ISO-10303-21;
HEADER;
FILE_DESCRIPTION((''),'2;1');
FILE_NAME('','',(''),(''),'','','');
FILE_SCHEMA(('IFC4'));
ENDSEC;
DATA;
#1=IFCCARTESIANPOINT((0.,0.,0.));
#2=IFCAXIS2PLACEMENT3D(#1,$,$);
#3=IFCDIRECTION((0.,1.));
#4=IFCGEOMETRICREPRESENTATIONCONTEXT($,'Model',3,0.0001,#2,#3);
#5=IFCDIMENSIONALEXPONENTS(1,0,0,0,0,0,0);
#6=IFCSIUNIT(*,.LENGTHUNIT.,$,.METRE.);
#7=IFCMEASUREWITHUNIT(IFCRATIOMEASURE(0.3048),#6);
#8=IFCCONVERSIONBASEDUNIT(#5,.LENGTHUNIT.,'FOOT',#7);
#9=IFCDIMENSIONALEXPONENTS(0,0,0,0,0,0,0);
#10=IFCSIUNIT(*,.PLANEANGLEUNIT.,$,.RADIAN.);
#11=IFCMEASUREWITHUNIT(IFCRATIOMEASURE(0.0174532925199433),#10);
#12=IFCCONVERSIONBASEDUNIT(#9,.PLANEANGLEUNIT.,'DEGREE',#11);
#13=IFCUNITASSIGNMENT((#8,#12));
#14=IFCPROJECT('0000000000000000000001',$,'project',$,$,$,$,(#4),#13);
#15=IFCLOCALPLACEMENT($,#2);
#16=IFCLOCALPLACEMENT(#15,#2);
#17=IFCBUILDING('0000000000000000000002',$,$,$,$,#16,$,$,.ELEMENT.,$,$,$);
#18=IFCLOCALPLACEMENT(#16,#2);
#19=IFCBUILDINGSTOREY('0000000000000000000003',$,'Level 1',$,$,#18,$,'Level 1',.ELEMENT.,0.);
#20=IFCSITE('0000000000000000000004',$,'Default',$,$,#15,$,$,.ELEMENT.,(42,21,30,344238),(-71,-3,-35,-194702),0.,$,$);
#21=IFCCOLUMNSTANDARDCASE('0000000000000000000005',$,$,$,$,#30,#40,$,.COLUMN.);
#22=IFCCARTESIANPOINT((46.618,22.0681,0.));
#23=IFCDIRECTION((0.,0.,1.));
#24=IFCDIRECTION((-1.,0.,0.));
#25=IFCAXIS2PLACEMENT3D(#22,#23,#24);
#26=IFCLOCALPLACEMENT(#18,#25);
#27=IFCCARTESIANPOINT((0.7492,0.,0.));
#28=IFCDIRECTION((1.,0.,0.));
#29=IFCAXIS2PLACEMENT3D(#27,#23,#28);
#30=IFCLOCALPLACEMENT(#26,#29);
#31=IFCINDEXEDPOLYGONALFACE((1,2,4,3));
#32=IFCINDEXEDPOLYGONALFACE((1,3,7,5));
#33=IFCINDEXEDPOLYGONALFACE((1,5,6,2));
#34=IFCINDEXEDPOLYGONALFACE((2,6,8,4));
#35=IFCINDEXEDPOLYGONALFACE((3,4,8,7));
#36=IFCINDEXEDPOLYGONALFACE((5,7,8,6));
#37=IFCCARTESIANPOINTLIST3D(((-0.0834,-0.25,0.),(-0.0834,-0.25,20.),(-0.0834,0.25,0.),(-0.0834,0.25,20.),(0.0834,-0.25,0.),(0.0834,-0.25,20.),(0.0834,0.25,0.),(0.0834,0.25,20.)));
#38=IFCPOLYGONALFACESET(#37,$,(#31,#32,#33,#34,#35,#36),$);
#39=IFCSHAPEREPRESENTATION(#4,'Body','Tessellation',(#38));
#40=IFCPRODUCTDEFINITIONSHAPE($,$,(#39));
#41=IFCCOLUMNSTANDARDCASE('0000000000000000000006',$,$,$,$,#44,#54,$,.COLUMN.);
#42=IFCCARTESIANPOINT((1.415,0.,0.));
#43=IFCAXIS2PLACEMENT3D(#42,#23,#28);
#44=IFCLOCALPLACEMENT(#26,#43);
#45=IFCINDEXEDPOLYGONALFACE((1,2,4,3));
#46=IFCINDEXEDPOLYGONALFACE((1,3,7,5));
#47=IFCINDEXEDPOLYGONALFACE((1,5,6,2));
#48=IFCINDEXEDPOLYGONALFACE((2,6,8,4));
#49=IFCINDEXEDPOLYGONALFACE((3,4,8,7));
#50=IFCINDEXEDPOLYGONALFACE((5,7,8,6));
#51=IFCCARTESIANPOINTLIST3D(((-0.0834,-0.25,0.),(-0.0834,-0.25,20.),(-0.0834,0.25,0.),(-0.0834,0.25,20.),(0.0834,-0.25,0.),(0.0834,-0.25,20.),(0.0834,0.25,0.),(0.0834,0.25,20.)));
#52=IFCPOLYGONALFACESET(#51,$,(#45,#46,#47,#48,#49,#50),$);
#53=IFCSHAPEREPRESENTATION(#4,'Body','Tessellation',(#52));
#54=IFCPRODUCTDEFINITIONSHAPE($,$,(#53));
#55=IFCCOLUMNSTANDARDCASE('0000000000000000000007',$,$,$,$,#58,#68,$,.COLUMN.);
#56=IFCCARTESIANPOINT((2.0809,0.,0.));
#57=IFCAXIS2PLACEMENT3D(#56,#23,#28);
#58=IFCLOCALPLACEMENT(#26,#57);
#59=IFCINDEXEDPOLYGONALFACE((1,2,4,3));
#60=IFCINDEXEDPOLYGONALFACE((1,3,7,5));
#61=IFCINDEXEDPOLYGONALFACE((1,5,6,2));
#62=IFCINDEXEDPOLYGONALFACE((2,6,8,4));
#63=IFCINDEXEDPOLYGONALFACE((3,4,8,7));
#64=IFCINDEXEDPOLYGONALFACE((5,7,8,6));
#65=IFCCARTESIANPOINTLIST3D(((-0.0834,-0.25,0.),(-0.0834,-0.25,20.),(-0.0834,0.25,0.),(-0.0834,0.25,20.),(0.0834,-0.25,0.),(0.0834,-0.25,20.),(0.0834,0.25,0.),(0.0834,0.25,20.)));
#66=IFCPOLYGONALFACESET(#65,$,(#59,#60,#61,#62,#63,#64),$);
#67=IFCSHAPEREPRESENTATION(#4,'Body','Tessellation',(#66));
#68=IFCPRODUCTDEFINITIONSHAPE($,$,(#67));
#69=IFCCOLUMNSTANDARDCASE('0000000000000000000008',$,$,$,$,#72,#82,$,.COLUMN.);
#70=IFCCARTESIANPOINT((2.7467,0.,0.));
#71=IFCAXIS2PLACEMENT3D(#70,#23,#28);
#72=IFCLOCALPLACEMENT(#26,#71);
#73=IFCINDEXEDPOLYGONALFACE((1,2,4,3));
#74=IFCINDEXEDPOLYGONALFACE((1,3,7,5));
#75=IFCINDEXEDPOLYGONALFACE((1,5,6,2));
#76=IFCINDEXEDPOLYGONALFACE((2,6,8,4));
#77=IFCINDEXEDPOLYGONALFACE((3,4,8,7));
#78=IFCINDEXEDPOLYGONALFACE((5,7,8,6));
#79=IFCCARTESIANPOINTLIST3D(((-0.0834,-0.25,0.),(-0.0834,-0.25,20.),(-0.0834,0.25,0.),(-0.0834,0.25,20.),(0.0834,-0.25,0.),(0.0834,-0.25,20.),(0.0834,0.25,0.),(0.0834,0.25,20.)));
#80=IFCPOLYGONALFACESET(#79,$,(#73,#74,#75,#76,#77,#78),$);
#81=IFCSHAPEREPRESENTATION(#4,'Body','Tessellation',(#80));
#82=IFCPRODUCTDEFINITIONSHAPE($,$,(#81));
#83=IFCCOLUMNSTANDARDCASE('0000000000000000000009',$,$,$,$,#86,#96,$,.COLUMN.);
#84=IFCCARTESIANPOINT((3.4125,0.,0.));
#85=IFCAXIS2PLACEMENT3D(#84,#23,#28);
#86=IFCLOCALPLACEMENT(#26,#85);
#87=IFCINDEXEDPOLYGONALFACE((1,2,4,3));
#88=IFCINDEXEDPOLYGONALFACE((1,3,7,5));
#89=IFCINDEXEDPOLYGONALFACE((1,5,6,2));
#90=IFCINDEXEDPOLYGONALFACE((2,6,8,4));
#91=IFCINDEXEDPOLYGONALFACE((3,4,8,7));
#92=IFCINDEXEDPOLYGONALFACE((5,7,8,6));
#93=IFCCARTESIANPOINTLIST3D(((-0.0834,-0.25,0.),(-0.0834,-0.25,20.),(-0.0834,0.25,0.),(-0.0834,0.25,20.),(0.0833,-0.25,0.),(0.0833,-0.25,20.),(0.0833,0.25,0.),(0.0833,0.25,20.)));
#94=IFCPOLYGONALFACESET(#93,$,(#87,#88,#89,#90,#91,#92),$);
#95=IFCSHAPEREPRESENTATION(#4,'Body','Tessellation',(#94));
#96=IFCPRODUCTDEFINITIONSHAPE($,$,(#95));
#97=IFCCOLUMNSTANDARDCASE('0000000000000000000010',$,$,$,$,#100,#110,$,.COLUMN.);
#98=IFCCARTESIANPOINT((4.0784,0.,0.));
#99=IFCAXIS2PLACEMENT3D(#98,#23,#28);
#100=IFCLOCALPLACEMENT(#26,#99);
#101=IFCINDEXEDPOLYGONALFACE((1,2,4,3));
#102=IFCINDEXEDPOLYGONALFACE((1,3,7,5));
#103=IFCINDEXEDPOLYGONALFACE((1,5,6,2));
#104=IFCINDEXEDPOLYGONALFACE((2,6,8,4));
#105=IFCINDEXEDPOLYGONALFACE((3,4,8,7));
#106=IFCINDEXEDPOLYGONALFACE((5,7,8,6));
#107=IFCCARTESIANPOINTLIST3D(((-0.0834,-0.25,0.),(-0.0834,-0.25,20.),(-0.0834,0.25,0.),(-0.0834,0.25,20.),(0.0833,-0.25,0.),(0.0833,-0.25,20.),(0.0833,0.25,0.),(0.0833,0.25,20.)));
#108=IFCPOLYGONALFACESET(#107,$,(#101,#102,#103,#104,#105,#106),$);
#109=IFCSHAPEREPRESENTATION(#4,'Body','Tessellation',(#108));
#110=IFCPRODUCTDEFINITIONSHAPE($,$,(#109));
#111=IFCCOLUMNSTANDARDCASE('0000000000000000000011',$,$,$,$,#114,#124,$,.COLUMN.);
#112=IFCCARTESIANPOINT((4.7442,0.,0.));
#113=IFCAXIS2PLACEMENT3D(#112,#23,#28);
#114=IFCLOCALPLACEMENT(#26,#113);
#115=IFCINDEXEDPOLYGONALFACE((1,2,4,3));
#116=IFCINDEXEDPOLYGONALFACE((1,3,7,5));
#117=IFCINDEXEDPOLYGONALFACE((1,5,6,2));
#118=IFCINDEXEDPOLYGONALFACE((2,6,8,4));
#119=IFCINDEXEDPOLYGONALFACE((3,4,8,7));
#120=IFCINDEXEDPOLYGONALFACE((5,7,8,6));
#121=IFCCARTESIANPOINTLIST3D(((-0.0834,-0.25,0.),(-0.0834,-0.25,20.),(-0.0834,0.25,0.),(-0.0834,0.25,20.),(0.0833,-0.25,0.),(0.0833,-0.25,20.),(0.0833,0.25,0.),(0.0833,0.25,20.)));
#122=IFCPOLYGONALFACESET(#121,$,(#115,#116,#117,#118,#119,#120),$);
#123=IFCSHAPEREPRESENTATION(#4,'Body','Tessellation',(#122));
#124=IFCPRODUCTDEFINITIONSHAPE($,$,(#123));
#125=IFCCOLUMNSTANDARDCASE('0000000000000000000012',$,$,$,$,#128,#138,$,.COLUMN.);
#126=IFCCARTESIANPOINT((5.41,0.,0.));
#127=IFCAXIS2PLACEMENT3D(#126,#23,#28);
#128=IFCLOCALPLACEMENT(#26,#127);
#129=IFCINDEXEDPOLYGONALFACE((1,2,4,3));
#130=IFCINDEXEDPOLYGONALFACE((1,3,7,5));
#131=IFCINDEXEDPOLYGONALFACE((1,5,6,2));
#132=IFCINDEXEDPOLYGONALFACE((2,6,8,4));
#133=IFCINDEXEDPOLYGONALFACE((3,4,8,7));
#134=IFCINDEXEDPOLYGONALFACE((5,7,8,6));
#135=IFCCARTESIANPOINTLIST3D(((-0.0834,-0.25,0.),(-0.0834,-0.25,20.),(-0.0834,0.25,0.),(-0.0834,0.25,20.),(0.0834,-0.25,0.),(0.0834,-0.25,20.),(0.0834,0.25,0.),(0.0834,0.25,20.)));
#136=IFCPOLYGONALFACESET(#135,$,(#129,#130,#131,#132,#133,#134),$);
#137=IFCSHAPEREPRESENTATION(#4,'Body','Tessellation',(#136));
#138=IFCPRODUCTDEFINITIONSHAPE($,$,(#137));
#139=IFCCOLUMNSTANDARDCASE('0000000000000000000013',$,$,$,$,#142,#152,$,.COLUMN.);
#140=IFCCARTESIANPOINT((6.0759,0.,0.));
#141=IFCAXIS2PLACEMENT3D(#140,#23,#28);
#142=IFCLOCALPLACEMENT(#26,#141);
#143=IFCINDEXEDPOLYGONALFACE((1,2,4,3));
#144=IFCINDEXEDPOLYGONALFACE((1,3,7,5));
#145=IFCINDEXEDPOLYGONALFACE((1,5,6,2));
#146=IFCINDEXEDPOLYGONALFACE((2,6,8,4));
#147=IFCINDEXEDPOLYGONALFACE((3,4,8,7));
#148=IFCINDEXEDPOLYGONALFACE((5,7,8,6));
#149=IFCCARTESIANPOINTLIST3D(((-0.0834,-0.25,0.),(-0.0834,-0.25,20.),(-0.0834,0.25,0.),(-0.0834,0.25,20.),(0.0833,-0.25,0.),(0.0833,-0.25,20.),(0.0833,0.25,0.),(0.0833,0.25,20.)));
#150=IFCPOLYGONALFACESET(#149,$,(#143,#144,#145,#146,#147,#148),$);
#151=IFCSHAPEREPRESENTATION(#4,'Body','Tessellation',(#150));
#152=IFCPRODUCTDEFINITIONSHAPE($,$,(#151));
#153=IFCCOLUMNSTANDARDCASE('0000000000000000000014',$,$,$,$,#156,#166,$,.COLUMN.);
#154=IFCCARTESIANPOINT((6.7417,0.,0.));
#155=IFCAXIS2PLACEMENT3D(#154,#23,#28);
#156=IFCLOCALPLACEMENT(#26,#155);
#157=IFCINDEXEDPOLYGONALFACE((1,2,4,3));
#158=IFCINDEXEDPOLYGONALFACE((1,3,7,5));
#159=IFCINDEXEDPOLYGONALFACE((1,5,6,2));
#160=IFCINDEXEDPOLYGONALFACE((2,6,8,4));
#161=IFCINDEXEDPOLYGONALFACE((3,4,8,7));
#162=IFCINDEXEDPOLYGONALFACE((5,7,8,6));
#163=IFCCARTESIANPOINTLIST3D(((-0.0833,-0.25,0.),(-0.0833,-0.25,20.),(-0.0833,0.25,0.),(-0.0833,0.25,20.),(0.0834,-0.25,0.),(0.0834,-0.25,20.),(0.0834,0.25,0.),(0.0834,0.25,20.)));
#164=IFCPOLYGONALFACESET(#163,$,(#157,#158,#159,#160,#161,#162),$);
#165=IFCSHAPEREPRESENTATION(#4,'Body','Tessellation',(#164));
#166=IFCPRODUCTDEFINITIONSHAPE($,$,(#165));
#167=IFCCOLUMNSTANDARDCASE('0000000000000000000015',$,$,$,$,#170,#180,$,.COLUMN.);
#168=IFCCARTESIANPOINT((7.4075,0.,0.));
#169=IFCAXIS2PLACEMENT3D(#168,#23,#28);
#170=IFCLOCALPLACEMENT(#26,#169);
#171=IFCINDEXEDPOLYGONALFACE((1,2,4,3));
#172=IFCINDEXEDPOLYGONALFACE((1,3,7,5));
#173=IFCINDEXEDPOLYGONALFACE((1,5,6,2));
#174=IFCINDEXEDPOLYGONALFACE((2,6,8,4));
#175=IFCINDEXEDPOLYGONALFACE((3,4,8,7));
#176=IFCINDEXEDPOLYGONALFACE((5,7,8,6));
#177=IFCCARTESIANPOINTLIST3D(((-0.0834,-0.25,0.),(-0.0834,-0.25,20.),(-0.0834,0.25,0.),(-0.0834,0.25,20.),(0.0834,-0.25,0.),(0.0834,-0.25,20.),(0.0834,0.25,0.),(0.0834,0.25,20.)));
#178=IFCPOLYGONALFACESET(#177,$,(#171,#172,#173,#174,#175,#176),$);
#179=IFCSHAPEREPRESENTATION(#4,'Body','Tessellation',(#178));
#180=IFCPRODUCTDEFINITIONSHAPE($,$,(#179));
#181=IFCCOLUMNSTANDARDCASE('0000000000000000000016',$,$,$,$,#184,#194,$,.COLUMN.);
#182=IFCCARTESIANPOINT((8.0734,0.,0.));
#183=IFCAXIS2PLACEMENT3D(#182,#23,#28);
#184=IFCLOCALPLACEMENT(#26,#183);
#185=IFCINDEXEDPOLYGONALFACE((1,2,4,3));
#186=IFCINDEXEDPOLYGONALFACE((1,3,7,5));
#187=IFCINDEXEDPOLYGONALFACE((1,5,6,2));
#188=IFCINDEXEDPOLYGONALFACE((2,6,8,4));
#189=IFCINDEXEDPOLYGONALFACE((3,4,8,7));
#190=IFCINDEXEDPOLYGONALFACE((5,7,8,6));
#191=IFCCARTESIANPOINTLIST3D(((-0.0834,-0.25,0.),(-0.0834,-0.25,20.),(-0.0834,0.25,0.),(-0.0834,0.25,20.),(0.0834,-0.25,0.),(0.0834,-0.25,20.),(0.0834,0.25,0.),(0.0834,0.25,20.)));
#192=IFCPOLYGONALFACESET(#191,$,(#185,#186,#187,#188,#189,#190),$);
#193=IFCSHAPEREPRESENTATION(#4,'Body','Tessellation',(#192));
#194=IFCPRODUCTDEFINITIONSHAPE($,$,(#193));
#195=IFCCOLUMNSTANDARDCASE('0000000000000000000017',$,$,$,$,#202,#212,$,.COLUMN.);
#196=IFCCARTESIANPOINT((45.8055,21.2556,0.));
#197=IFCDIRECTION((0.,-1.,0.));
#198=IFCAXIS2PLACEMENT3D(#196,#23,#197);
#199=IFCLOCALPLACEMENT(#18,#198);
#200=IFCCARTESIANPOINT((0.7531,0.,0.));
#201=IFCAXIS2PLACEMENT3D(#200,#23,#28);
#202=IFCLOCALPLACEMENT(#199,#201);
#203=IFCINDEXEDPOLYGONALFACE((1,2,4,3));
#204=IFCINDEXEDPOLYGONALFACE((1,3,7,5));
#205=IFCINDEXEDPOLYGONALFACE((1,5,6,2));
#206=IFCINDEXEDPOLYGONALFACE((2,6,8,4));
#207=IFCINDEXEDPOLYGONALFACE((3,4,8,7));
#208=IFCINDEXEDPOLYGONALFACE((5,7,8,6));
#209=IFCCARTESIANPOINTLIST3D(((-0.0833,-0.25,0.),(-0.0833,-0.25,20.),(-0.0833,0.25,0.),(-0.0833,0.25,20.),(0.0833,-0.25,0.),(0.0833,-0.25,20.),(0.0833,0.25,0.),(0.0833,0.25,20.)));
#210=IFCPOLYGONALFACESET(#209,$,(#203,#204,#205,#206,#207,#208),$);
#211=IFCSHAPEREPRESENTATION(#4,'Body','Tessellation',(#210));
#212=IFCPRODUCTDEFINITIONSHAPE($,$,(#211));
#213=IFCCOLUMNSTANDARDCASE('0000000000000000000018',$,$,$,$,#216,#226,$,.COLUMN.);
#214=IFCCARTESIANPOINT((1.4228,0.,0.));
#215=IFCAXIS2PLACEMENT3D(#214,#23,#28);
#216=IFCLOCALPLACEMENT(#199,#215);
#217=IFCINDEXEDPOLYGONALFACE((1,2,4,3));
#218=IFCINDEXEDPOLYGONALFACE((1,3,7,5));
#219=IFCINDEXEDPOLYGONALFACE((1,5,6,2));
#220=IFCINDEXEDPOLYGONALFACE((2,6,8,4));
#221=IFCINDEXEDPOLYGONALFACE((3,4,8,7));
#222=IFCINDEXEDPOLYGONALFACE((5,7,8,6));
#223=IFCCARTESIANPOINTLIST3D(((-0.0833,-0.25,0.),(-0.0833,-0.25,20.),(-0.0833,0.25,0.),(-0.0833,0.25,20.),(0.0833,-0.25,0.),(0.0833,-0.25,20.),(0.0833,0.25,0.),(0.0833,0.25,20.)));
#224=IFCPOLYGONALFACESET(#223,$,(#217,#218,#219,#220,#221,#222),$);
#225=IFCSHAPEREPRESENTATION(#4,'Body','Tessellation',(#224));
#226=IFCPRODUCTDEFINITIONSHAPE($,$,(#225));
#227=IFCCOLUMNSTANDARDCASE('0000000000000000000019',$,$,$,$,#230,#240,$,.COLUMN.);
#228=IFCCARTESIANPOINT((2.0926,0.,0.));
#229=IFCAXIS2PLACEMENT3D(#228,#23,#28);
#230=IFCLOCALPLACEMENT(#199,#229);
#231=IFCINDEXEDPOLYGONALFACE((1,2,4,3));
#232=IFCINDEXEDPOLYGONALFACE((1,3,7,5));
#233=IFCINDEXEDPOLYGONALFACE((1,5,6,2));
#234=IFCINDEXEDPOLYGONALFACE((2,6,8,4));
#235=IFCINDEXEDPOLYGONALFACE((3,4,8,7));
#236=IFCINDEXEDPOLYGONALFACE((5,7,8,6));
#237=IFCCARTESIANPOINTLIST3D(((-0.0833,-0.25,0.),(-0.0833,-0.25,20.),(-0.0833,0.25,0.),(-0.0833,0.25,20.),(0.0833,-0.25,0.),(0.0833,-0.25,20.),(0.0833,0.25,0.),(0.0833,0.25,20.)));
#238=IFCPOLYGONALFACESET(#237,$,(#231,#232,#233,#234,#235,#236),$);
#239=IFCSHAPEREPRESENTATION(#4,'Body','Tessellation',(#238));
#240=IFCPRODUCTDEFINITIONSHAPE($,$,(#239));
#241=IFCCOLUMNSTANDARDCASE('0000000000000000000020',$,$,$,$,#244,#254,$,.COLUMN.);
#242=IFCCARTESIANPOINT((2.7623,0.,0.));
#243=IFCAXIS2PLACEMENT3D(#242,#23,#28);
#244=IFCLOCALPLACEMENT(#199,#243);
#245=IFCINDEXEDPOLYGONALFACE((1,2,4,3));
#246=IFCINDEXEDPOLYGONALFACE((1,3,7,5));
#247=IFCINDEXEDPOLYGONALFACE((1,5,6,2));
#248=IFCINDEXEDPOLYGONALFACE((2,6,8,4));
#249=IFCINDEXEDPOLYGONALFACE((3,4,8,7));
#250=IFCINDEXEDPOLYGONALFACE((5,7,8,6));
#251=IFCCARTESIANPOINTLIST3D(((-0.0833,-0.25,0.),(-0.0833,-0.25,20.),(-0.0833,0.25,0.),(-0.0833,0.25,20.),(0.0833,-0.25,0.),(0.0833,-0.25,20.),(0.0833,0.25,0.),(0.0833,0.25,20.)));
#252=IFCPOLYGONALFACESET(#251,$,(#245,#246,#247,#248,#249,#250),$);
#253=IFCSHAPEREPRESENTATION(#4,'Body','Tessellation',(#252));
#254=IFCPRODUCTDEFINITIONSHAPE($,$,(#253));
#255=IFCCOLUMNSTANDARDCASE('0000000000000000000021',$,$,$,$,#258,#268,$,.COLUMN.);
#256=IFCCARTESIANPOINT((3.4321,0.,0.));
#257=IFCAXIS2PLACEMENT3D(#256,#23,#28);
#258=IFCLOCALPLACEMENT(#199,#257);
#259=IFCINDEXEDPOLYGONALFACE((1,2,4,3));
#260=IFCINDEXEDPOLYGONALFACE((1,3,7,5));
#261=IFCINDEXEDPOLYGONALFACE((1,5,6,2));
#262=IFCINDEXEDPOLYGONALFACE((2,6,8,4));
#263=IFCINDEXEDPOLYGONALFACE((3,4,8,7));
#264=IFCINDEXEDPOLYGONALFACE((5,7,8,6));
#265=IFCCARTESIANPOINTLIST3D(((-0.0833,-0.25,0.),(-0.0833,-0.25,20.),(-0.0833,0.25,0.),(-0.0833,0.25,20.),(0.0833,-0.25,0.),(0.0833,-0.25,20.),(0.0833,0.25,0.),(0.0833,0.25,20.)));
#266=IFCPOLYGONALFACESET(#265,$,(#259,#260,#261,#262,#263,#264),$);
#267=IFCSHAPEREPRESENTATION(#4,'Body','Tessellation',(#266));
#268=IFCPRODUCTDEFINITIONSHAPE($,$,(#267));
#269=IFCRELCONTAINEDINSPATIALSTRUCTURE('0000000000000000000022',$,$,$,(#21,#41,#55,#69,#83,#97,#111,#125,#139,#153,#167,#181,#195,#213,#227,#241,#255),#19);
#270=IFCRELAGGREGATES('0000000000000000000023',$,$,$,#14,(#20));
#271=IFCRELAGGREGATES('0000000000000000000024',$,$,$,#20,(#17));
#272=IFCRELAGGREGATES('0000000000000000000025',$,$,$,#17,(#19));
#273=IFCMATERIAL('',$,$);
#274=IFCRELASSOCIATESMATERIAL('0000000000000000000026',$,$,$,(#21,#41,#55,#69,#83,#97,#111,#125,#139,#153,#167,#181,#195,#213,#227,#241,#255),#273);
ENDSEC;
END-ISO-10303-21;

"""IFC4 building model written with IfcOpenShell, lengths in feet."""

from ifc_helpers import new_model, entity, si_unit, converted_unit, direction, frame, origin, place, context, project, spatial, rectangle, extrude, material, element, save


model = new_model("IFC4")

# Units and contexts
model_context = context("Model", 3, precision=0.0001, world=origin(), true_north=direction((0.0, 1.0)))
ifc_project = project(units=[converted_unit("LENGTHUNIT", "FOOT", entity("IfcRatioMeasure", 0.3048), si_unit("LENGTHUNIT", "METRE"), dimensions=[1, 0, 0, 0, 0, 0, 0]), converted_unit("PLANEANGLEUNIT", "DEGREE", entity("IfcRatioMeasure", 0.0174532925199433), si_unit("PLANEANGLEUNIT", "RADIAN"), dimensions=[0, 0, 0, 0, 0, 0, 0])], contexts=[model_context])

# Site, building, storey
site_placement = place(None, origin())
site = spatial("IfcSite", under=ifc_project, at=site_placement, Name="Default", CompositionType="ELEMENT", RefLatitude=(42, 21, 30, 344238), RefLongitude=(-71, -3, -35, -194702), RefElevation=0.0)
building_placement = place(site_placement, origin())
building = spatial("IfcBuilding", under=site, at=building_placement, CompositionType="ELEMENT")
storey_placement = place(building_placement, origin())
storey = spatial("IfcBuildingStorey", under=building, at=storey_placement, Name="Level 1", LongName="Level 1", CompositionType="ELEMENT", Elevation=0.0)

# Columns
ifc_material_1 = material(Name="")
wall_1_placement = place(storey_placement, frame((46.618, 22.0681, 0.0), z_axis=(0.0, 0.0, 1.0), x_axis=(-1.0, 0.0, 0.0)))
for number, where, z_axis, x_axis in (
    (1, (0.7492, 0.0, 0.0), (0.0, 0.0, 1.0), (1.0, 0.0, 0.0)),
    (2, (1.415, 0.0, 0.0), (0.0, 0.0, 1.0), (1.0, 0.0, 0.0)),
    (3, (2.0809, 0.0, 0.0), (0.0, 0.0, 1.0), (1.0, 0.0, 0.0)),
    (4, (2.7467, 0.0, 0.0), (0.0, 0.0, 1.0), (1.0, 0.0, 0.0)),
    (5, (3.4125, 0.0, 0.0), (0.0, 0.0, 1.0), (1.0, 0.0, 0.0)),
    (6, (4.0784, 0.0, 0.0), (0.0, 0.0, 1.0), (1.0, 0.0, 0.0)),
    (7, (4.7442, 0.0, 0.0), (0.0, 0.0, 1.0), (1.0, 0.0, 0.0)),
    (8, (5.41, 0.0, 0.0), (0.0, 0.0, 1.0), (1.0, 0.0, 0.0)),
    (9, (6.0759, 0.0, 0.0), (0.0, 0.0, 1.0), (1.0, 0.0, 0.0)),
    (10, (6.7417, 0.0, 0.0), (0.0, 0.0, 1.0), (1.0, 0.0, 0.0)),
    (11, (7.4075, 0.0, 0.0), (0.0, 0.0, 1.0), (1.0, 0.0, 0.0)),
    (12, (8.0734, 0.0, 0.0), (0.0, 0.0, 1.0), (1.0, 0.0, 0.0)),
):
    element("IfcColumnStandardCase", number, at=place(wall_1_placement, frame(where, z_axis=z_axis, x_axis=x_axis)), inside=storey, material=ifc_material_1, PredefinedType="COLUMN", context=model_context, shape_type="SweptSolid", body=[
        extrude(rectangle(XDim=0.1667, YDim=0.5), origin(), (0.0, 0.0, 1.0), 20.0),
    ])
wall_2_placement = place(storey_placement, frame((45.8055, 21.2556, 0.0), z_axis=(0.0, 0.0, 1.0), x_axis=(0.0, -1.0, 0.0)))
for number, where, z_axis, x_axis in (
    (13, (0.7531, 0.0, 0.0), (0.0, 0.0, 1.0), (1.0, 0.0, 0.0)),
    (14, (1.4228, 0.0, 0.0), (0.0, 0.0, 1.0), (1.0, 0.0, 0.0)),
    (15, (2.0926, 0.0, 0.0), (0.0, 0.0, 1.0), (1.0, 0.0, 0.0)),
    (16, (2.7623, 0.0, 0.0), (0.0, 0.0, 1.0), (1.0, 0.0, 0.0)),
    (17, (3.4321, 0.0, 0.0), (0.0, 0.0, 1.0), (1.0, 0.0, 0.0)),
):
    element("IfcColumnStandardCase", number, at=place(wall_2_placement, frame(where, z_axis=z_axis, x_axis=x_axis)), inside=storey, material=ifc_material_1, PredefinedType="COLUMN", context=model_context, shape_type="SweptSolid", body=[
        extrude(rectangle(XDim=0.1667, YDim=0.5), origin(), (0.0, 0.0, 1.0), 20.0),
    ])

save(model, "model.ifc")
